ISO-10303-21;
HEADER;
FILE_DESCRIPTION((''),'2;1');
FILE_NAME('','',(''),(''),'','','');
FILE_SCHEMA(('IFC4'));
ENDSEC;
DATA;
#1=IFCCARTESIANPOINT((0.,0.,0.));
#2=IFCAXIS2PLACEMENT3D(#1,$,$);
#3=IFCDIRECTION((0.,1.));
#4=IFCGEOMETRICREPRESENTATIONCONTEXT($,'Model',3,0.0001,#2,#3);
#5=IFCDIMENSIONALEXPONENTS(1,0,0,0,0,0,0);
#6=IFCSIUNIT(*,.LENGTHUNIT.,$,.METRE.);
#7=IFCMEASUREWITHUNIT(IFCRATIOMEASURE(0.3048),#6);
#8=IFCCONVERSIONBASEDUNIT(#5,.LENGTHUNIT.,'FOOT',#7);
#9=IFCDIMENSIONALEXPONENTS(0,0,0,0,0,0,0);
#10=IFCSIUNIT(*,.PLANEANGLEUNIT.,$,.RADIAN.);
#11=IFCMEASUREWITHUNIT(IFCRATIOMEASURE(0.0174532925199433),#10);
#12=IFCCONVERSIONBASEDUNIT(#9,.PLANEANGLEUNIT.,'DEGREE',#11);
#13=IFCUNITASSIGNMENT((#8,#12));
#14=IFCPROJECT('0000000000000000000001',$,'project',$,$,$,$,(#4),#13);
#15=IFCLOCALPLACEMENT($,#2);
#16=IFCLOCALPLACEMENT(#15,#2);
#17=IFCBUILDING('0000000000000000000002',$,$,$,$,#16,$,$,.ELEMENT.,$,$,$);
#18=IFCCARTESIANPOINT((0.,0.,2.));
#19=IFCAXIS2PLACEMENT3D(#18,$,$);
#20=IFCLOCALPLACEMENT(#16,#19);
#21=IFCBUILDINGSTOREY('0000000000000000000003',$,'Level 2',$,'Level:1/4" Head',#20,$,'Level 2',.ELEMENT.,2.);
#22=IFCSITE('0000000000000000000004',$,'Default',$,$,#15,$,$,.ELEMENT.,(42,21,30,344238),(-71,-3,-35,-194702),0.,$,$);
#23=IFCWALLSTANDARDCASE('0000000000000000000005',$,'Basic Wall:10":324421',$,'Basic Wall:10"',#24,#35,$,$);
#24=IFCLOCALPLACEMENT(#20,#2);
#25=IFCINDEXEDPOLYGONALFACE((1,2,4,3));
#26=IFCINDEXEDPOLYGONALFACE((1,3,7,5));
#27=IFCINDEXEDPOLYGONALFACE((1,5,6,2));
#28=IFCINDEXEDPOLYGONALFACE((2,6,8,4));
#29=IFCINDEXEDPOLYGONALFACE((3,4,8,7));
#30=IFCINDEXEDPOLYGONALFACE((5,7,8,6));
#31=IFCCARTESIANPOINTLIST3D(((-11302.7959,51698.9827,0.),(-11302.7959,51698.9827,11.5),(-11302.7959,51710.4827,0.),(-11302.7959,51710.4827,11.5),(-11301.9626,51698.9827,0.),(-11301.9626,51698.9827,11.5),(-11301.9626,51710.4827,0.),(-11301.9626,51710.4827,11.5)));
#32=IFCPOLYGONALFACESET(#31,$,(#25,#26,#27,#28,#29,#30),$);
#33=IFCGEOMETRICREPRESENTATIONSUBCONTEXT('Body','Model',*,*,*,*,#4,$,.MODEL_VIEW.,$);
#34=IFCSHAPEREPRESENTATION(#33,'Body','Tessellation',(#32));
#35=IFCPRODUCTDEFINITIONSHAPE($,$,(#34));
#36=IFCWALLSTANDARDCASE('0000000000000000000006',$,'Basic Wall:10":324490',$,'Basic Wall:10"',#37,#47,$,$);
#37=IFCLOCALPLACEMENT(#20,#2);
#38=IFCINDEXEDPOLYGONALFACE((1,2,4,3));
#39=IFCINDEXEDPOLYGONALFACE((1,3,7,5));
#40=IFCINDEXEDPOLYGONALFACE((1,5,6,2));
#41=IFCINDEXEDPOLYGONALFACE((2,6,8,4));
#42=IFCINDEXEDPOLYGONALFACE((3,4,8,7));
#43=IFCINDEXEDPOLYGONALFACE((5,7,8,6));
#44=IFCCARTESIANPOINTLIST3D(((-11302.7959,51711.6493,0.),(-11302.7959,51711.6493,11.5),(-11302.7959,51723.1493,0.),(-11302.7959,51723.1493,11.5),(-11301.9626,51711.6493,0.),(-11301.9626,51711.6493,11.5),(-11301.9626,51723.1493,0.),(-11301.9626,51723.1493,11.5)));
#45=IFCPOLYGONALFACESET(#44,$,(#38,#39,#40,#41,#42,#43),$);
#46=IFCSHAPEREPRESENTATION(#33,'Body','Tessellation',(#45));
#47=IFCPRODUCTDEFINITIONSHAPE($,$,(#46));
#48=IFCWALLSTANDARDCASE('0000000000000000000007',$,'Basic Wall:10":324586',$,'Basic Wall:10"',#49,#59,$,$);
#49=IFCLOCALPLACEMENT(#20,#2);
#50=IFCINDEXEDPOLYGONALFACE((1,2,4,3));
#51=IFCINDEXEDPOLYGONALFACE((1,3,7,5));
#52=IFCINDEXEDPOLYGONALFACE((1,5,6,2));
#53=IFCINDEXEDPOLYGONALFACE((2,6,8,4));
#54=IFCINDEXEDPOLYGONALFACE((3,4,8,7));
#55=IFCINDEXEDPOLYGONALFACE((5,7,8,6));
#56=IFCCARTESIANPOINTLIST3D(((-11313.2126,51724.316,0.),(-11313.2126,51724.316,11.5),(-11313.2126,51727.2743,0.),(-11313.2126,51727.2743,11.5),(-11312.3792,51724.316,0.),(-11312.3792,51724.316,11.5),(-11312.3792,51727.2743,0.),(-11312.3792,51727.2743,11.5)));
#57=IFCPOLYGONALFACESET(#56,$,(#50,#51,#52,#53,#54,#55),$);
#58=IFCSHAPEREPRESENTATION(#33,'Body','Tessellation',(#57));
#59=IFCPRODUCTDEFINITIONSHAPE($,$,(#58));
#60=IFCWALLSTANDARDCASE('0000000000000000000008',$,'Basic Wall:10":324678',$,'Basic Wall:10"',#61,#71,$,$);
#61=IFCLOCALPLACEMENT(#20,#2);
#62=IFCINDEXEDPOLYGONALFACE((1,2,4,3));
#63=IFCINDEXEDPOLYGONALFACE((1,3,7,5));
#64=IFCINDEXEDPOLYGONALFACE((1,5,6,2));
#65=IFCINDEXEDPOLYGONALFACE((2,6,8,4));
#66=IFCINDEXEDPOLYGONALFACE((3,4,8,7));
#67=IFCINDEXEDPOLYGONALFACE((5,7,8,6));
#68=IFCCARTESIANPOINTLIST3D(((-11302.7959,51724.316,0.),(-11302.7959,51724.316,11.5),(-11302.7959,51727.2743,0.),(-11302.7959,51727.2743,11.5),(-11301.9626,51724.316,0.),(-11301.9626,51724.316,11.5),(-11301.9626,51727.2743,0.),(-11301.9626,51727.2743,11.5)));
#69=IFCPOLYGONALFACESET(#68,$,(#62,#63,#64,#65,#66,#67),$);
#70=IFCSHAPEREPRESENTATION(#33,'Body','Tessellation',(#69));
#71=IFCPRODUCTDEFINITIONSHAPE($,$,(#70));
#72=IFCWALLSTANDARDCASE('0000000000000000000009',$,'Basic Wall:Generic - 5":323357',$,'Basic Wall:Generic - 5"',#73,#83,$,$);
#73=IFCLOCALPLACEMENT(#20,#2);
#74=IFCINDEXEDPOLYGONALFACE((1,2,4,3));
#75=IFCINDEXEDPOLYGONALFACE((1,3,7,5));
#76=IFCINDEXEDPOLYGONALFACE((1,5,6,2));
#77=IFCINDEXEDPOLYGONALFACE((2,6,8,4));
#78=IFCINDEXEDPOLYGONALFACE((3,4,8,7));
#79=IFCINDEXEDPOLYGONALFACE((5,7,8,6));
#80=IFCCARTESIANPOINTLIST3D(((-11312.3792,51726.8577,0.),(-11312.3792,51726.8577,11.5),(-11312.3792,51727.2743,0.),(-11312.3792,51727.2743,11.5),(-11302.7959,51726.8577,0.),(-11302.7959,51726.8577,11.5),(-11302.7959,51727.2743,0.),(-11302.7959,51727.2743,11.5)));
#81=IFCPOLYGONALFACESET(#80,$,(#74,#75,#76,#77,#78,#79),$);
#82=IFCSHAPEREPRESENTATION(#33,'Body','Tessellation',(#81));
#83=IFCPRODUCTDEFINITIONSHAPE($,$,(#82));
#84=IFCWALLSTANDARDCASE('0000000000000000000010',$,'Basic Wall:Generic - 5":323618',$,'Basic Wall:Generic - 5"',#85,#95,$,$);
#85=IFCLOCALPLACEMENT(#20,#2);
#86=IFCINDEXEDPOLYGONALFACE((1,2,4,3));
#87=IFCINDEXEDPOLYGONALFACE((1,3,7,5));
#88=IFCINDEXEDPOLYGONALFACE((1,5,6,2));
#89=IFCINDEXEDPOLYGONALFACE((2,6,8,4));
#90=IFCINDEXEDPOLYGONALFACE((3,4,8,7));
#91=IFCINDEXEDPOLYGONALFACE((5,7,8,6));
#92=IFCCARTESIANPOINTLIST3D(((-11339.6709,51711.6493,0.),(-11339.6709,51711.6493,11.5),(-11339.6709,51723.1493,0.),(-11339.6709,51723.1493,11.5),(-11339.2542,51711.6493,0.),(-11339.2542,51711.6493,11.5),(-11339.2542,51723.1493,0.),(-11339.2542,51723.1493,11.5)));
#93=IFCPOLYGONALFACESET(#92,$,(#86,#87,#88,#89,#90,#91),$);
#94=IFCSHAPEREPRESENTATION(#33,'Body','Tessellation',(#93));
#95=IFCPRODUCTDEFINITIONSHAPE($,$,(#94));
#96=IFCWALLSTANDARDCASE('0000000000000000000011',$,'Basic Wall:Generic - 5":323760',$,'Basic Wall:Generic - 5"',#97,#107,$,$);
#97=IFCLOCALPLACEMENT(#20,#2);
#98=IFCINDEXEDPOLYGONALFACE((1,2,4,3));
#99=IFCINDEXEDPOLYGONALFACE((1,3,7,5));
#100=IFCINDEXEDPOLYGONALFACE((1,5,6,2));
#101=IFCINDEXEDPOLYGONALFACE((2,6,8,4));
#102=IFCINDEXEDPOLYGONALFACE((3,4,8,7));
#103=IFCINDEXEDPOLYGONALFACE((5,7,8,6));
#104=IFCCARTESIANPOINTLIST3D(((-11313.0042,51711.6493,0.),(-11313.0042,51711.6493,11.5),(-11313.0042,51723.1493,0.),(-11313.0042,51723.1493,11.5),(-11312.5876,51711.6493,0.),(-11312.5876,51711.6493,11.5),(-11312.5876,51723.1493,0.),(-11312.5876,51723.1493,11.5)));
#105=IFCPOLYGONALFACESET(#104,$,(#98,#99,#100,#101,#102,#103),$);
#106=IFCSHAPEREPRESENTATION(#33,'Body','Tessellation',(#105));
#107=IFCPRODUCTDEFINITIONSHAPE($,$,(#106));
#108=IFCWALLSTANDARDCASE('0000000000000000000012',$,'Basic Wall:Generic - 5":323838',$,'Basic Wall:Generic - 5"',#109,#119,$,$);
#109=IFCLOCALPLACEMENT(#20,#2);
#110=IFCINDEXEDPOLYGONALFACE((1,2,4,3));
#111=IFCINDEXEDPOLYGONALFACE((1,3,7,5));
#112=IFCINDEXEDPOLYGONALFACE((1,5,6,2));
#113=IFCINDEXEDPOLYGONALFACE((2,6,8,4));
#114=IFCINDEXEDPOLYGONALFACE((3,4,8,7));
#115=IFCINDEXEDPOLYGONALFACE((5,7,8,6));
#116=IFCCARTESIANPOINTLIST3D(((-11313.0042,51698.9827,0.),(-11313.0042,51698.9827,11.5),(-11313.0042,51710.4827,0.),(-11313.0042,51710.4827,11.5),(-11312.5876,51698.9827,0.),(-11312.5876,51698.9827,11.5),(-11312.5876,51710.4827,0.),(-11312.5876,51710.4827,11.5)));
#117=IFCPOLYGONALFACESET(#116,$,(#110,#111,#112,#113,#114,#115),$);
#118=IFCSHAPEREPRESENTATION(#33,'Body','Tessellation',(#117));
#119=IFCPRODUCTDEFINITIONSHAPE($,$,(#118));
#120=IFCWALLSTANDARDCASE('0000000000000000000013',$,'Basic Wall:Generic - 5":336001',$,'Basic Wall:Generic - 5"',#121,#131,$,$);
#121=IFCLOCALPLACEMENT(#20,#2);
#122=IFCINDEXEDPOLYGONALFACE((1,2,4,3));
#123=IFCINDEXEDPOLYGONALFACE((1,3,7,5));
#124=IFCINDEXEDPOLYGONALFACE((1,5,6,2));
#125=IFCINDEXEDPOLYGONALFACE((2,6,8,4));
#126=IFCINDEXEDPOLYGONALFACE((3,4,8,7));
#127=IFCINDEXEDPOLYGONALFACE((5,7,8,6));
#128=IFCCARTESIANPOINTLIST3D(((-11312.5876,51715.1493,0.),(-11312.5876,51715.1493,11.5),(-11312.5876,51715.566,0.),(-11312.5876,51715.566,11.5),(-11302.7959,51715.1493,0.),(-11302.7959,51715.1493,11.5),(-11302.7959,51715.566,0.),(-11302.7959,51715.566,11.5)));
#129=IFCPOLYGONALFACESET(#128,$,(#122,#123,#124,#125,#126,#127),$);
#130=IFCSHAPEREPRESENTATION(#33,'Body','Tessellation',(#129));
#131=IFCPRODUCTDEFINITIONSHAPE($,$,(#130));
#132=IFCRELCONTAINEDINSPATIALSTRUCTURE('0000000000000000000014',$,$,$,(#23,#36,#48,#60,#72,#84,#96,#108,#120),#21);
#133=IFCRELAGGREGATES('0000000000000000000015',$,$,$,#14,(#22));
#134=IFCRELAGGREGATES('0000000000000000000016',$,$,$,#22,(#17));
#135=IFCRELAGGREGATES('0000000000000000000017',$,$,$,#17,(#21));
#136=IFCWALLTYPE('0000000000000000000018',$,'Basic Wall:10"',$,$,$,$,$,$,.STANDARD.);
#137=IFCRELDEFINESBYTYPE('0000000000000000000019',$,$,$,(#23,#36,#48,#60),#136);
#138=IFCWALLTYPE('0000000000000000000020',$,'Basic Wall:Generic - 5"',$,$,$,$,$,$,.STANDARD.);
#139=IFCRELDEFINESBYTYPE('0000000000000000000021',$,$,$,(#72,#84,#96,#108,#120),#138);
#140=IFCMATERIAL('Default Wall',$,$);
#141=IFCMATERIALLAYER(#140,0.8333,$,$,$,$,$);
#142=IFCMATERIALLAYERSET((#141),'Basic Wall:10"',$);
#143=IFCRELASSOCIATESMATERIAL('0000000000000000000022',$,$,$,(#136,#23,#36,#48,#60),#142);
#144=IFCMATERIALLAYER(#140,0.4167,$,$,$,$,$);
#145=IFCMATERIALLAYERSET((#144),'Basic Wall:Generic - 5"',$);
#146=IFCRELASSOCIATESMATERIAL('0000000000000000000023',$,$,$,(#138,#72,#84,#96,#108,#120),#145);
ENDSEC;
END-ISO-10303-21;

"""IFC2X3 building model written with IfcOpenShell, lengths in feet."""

from ifc_helpers import new_model, entity, si_unit, converted_unit, direction, frame, frame_2d, origin, place, context, subcontext, project, spatial, rectangle, extrude, material, layer, layer_set, layer_usage, type_object, element, save


model = new_model("IFC2X3")

# Units and contexts
model_context = context("Model", 3, precision=0.0001, world=origin(), true_north=direction((0.0, 1.0)))
body_context = subcontext(model_context, "Body", "Model", "MODEL_VIEW")
ifc_project = project(units=[converted_unit("LENGTHUNIT", "FOOT", entity("IfcRatioMeasure", 0.3048), si_unit("LENGTHUNIT", "METRE"), dimensions=[1, 0, 0, 0, 0, 0, 0]), converted_unit("PLANEANGLEUNIT", "DEGREE", entity("IfcRatioMeasure", 0.0174532925199433), si_unit("PLANEANGLEUNIT", "RADIAN"), dimensions=[0, 0, 0, 0, 0, 0, 0])], contexts=[model_context])

# Site, building, storey
site_placement = place(None, origin())
site = spatial("IfcSite", under=ifc_project, at=site_placement, Name="Default", CompositionType="ELEMENT", RefLatitude=(42, 21, 30, 344238), RefLongitude=(-71, -3, -35, -194702), RefElevation=0.0)
building_placement = place(site_placement, origin())
building = spatial("IfcBuilding", under=site, at=building_placement, CompositionType="ELEMENT")
storey_placement = place(building_placement, frame((0.0, 0.0, 2.0)))
storey = spatial("IfcBuildingStorey", under=building, at=storey_placement, Name="Level 2", ObjectType="Level:1/4\" Head", LongName="Level 2", CompositionType="ELEMENT", Elevation=2.0)

# Walls
ifc_material_1 = material(Name="Default Wall")
ifc_layer_1 = layer(ifc_material_1, 0.8333)
ifc_layer_set_1 = layer_set([ifc_layer_1], Name="Basic Wall:10\"")
ifc_layer_usage_1 = layer_usage(ifc_layer_set_1, "AXIS2", "NEGATIVE", 0.4167)
wall_type_1 = type_object("IfcWallType", Name="Basic Wall:10\"", PredefinedType="STANDARD", material=ifc_layer_set_1)
wall_1_placement = place(storey_placement, frame((-11302.3792, 51698.9827, 0.0), z_axis=(0.0, 0.0, 1.0), x_axis=(0.0, 1.0, 0.0)))
element("IfcWallStandardCase", 1, at=wall_1_placement, inside=storey, type_object=wall_type_1, material=ifc_layer_usage_1, Name="Basic Wall:10\":324421", ObjectType="Basic Wall:10\"", context=body_context, shape_type="SweptSolid", body=[
    extrude(rectangle(XDim=11.5, YDim=0.8333, at=frame_2d((5.75, 0.0), x_axis=(-1.0, 0.0))), origin(), (0.0, 0.0, 1.0), 11.5),
])
ifc_layer_usage_2 = layer_usage(ifc_layer_set_1, "AXIS2", "NEGATIVE", 0.4167)
wall_2_placement = place(storey_placement, frame((-11302.3792, 51711.6493, 0.0), z_axis=(0.0, 0.0, 1.0), x_axis=(0.0, 1.0, 0.0)))
element("IfcWallStandardCase", 2, at=wall_2_placement, inside=storey, type_object=wall_type_1, material=ifc_layer_usage_2, Name="Basic Wall:10\":324490", ObjectType="Basic Wall:10\"", context=body_context, shape_type="SweptSolid", body=[
    extrude(rectangle(XDim=11.5, YDim=0.8333, at=frame_2d((5.75, 0.0), x_axis=(-1.0, 0.0))), origin(), (0.0, 0.0, 1.0), 11.5),
])
ifc_layer_usage_3 = layer_usage(ifc_layer_set_1, "AXIS2", "NEGATIVE", 0.4167)
wall_3_placement = place(storey_placement, frame((-11312.7959, 51724.316, 0.0), z_axis=(0.0, 0.0, 1.0), x_axis=(0.0, 1.0, 0.0)))
element("IfcWallStandardCase", 3, at=wall_3_placement, inside=storey, type_object=wall_type_1, material=ifc_layer_usage_3, Name="Basic Wall:10\":324586", ObjectType="Basic Wall:10\"", context=body_context, shape_type="SweptSolid", body=[
    extrude(rectangle(XDim=2.9583, YDim=0.8333, at=frame_2d((1.4792, 0.0), x_axis=(-1.0, 0.0))), origin(), (0.0, 0.0, 1.0), 11.5),
])
ifc_layer_usage_4 = layer_usage(ifc_layer_set_1, "AXIS2", "NEGATIVE", 0.4167)
wall_4_placement = place(storey_placement, frame((-11302.3792, 51724.316, 0.0), z_axis=(0.0, 0.0, 1.0), x_axis=(0.0, 1.0, 0.0)))
element("IfcWallStandardCase", 4, at=wall_4_placement, inside=storey, type_object=wall_type_1, material=ifc_layer_usage_4, Name="Basic Wall:10\":324678", ObjectType="Basic Wall:10\"", context=body_context, shape_type="SweptSolid", body=[
    extrude(rectangle(XDim=2.9583, YDim=0.8333, at=frame_2d((1.4792, 0.0), x_axis=(-1.0, 0.0))), origin(), (0.0, 0.0, 1.0), 11.5),
])

# Shared definitions
ifc_layer_2 = layer(ifc_material_1, 0.4167)
ifc_layer_set_2 = layer_set([ifc_layer_2], Name="Basic Wall:Generic - 5\"")
wall_type_2 = type_object("IfcWallType", Name="Basic Wall:Generic - 5\"", PredefinedType="STANDARD", material=ifc_layer_set_2)

# Walls
ifc_layer_usage_5 = layer_usage(ifc_layer_set_2, "AXIS2", "NEGATIVE", 0.2083)
wall_5_placement = place(storey_placement, frame((-11312.3792, 51727.066, 0.0)))
element("IfcWallStandardCase", 5, at=wall_5_placement, inside=storey, type_object=wall_type_2, material=ifc_layer_usage_5, Name="Basic Wall:Generic - 5\":323357", ObjectType="Basic Wall:Generic - 5\"", context=body_context, shape_type="SweptSolid", body=[
    extrude(rectangle(XDim=9.5833, YDim=0.4167, at=frame_2d((4.7917, 0.0), x_axis=(-1.0, 0.0))), origin(), (0.0, 0.0, 1.0), 11.5),
])
ifc_layer_usage_6 = layer_usage(ifc_layer_set_2, "AXIS2", "NEGATIVE", 0.2083)
wall_6_placement = place(storey_placement, frame((-11339.4626, 51723.1493, 0.0), z_axis=(0.0, 0.0, 1.0), x_axis=(0.0, -1.0, 0.0)))
element("IfcWallStandardCase", 6, at=wall_6_placement, inside=storey, type_object=wall_type_2, material=ifc_layer_usage_6, Name="Basic Wall:Generic - 5\":323618", ObjectType="Basic Wall:Generic - 5\"", context=body_context, shape_type="SweptSolid", body=[
    extrude(rectangle(XDim=11.5, YDim=0.4167, at=frame_2d((5.75, 0.0), x_axis=(-1.0, 0.0))), origin(), (0.0, 0.0, 1.0), 11.5),
])
ifc_layer_usage_7 = layer_usage(ifc_layer_set_2, "AXIS2", "NEGATIVE", 0.2083)
wall_7_placement = place(storey_placement, frame((-11312.7959, 51723.1493, 0.0), z_axis=(0.0, 0.0, 1.0), x_axis=(0.0, -1.0, 0.0)))
element("IfcWallStandardCase", 7, at=wall_7_placement, inside=storey, type_object=wall_type_2, material=ifc_layer_usage_7, Name="Basic Wall:Generic - 5\":323760", ObjectType="Basic Wall:Generic - 5\"", context=body_context, shape_type="SweptSolid", body=[
    extrude(rectangle(XDim=11.5, YDim=0.4167, at=frame_2d((5.75, 0.0), x_axis=(-1.0, 0.0))), origin(), (0.0, 0.0, 1.0), 11.5),
])
ifc_layer_usage_8 = layer_usage(ifc_layer_set_2, "AXIS2", "NEGATIVE", 0.2083)
wall_8_placement = place(storey_placement, frame((-11312.7959, 51710.4827, 0.0), z_axis=(0.0, 0.0, 1.0), x_axis=(0.0, -1.0, 0.0)))
element("IfcWallStandardCase", 8, at=wall_8_placement, inside=storey, type_object=wall_type_2, material=ifc_layer_usage_8, Name="Basic Wall:Generic - 5\":323838", ObjectType="Basic Wall:Generic - 5\"", context=body_context, shape_type="SweptSolid", body=[
    extrude(rectangle(XDim=11.5, YDim=0.4167, at=frame_2d((5.75, 0.0), x_axis=(-1.0, 0.0))), origin(), (0.0, 0.0, 1.0), 11.5),
])
ifc_layer_usage_9 = layer_usage(ifc_layer_set_2, "AXIS2", "NEGATIVE", 0.2083)
wall_9_placement = place(storey_placement, frame((-11312.5876, 51715.3577, 0.0)))
element("IfcWallStandardCase", 9, at=wall_9_placement, inside=storey, type_object=wall_type_2, material=ifc_layer_usage_9, Name="Basic Wall:Generic - 5\":336001", ObjectType="Basic Wall:Generic - 5\"", context=body_context, shape_type="SweptSolid", body=[
    extrude(rectangle(XDim=9.7917, YDim=0.4167, at=frame_2d((4.8958, 0.0), x_axis=(-1.0, 0.0))), origin(), (0.0, 0.0, 1.0), 11.5),
])

save(model, "model.ifc")
